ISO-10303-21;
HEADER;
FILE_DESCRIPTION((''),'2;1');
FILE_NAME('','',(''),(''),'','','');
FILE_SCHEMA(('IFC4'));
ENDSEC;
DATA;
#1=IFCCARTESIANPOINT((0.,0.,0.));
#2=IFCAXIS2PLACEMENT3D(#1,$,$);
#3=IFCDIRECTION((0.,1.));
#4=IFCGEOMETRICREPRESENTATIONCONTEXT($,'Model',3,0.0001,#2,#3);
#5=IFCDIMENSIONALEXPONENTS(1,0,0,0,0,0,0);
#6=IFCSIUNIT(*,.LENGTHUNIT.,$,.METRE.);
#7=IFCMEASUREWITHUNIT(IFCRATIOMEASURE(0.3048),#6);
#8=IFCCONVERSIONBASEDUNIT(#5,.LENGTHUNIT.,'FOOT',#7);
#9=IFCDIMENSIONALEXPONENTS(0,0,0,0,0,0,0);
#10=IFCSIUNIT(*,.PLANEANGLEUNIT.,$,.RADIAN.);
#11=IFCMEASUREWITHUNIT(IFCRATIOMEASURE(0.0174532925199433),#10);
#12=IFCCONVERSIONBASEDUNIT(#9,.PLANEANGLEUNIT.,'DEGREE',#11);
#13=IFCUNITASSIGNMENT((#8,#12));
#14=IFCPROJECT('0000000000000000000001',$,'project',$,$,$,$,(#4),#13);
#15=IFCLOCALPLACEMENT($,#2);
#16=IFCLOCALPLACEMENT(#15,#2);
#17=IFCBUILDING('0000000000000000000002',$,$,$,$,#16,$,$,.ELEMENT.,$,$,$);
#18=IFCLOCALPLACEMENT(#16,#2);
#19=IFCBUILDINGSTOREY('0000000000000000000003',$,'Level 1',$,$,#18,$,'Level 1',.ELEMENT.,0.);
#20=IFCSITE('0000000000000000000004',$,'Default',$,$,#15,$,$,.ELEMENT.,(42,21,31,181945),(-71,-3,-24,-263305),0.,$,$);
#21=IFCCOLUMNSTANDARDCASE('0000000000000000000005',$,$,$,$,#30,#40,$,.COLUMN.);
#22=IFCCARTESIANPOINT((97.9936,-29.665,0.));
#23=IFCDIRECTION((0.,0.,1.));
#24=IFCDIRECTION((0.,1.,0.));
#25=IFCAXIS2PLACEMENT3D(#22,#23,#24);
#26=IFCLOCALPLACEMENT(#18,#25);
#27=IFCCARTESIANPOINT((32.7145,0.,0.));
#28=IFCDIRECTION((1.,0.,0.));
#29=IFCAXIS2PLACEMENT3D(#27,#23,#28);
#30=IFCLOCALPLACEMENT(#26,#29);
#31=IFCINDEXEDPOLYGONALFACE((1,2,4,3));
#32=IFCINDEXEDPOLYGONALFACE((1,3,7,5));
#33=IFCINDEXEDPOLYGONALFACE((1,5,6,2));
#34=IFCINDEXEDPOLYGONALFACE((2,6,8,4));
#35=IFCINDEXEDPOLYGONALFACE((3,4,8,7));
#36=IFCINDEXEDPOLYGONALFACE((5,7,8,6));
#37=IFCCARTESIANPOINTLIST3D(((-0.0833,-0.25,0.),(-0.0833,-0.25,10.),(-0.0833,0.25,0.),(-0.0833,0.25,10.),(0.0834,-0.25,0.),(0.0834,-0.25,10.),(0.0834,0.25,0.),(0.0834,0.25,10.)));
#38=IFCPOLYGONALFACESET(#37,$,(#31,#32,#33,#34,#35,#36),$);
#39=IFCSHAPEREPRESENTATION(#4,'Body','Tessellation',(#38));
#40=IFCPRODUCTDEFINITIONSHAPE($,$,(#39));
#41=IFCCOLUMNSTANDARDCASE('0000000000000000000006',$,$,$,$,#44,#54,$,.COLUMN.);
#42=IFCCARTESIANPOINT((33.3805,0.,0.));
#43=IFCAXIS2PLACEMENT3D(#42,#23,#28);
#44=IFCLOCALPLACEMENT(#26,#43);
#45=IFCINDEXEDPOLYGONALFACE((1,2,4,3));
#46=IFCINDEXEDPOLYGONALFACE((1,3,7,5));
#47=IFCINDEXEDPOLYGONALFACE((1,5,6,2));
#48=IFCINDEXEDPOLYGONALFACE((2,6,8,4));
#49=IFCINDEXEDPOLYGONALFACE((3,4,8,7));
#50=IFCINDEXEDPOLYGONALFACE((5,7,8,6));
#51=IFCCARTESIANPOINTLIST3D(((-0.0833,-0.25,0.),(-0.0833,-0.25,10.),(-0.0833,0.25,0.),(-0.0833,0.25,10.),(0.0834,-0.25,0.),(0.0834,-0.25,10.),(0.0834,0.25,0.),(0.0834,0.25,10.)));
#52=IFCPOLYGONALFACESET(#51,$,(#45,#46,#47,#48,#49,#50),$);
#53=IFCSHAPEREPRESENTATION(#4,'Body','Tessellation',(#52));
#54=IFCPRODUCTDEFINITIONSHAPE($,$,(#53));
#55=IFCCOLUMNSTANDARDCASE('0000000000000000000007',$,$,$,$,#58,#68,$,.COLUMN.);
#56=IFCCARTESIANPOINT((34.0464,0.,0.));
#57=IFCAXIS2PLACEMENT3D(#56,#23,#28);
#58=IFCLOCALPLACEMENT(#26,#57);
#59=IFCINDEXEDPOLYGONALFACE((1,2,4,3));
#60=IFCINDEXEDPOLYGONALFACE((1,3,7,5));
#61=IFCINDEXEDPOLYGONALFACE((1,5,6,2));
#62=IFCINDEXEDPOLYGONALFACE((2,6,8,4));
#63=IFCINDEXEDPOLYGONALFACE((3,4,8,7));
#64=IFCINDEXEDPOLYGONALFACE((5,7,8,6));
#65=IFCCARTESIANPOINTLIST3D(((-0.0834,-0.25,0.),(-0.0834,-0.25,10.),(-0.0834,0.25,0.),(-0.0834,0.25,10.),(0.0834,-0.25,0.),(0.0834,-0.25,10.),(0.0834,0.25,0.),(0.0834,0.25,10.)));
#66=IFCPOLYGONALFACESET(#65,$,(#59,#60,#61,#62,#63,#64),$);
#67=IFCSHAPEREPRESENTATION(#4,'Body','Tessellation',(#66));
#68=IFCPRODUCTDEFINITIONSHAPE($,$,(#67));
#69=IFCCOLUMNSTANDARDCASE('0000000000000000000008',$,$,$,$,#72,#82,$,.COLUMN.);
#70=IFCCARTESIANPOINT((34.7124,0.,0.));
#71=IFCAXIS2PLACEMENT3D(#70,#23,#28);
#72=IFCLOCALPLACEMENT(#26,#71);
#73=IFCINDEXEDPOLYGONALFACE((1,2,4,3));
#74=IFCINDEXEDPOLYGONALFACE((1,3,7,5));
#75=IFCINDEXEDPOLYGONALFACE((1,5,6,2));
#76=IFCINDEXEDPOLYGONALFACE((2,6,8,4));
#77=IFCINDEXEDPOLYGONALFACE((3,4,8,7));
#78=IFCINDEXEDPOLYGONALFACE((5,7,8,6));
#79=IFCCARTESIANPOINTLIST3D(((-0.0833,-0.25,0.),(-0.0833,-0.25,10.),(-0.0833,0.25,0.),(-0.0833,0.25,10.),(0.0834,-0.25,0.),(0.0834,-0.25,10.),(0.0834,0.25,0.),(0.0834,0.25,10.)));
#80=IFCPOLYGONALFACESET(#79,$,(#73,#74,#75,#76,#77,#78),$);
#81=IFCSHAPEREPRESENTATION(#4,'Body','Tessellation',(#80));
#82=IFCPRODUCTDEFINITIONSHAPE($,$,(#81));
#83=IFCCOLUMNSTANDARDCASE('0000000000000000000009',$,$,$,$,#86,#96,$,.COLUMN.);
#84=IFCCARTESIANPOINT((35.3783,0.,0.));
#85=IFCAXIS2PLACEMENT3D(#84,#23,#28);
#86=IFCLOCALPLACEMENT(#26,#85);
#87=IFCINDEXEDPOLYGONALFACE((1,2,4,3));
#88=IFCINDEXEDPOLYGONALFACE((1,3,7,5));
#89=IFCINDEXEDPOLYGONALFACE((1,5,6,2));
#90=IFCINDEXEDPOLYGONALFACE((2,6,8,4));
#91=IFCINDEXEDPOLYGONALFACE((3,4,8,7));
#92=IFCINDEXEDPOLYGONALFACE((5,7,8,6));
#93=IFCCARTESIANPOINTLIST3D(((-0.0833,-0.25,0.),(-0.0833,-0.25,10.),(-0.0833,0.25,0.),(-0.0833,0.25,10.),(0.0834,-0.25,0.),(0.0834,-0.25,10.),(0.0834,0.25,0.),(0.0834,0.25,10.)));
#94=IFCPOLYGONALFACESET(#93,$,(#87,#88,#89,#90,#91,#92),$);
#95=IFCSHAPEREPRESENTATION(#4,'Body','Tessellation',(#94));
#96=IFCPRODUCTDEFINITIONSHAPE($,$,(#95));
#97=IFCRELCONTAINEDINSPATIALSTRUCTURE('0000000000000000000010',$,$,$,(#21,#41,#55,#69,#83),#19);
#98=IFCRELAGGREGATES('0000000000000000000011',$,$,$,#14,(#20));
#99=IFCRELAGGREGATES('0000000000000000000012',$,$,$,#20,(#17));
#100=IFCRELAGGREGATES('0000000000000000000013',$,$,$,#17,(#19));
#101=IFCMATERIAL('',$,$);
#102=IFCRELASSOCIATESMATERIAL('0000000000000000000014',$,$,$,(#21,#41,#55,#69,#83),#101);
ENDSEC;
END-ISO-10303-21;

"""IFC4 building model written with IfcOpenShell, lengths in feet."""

from ifc_helpers import new_model, entity, si_unit, converted_unit, direction, frame, origin, place, context, project, spatial, rectangle, extrude, material, element, save


model = new_model("IFC4")

# Units and contexts
model_context = context("Model", 3, precision=0.0001, world=origin(), true_north=direction((0.0, 1.0)))
ifc_project = project(units=[converted_unit("LENGTHUNIT", "FOOT", entity("IfcRatioMeasure", 0.3048), si_unit("LENGTHUNIT", "METRE"), dimensions=[1, 0, 0, 0, 0, 0, 0]), converted_unit("PLANEANGLEUNIT", "DEGREE", entity("IfcRatioMeasure", 0.0174532925199433), si_unit("PLANEANGLEUNIT", "RADIAN"), dimensions=[0, 0, 0, 0, 0, 0, 0])], contexts=[model_context])

# Site, building, storey
site_placement = place(None, origin())
site = spatial("IfcSite", under=ifc_project, at=site_placement, Name="Default", CompositionType="ELEMENT", RefLatitude=(42, 21, 31, 181945), RefLongitude=(-71, -3, -24, -263305), RefElevation=0.0)
building_placement = place(site_placement, origin())
building = spatial("IfcBuilding", under=site, at=building_placement, CompositionType="ELEMENT")
storey_placement = place(building_placement, origin())
storey = spatial("IfcBuildingStorey", under=building, at=storey_placement, Name="Level 1", LongName="Level 1", CompositionType="ELEMENT", Elevation=0.0)

# Columns
ifc_material = material(Name="")
placement = place(storey_placement, frame((97.9936, -29.665, 0.0), z_axis=(0.0, 0.0, 1.0), x_axis=(0.0, 1.0, 0.0)))
for number, where, z_axis, x_axis in (
    (1, (32.7145, 0.0, 0.0), (0.0, 0.0, 1.0), (1.0, 0.0, 0.0)),
    (2, (33.3805, 0.0, 0.0), (0.0, 0.0, 1.0), (1.0, 0.0, 0.0)),
    (3, (34.0464, 0.0, 0.0), (0.0, 0.0, 1.0), (1.0, 0.0, 0.0)),
    (4, (34.7124, 0.0, 0.0), (0.0, 0.0, 1.0), (1.0, 0.0, 0.0)),
    (5, (35.3783, 0.0, 0.0), (0.0, 0.0, 1.0), (1.0, 0.0, 0.0)),
):
    element("IfcColumnStandardCase", number, at=place(placement, frame(where, z_axis=z_axis, x_axis=x_axis)), inside=storey, material=ifc_material, PredefinedType="COLUMN", context=model_context, shape_type="SweptSolid", body=[
        extrude(rectangle(XDim=0.1667, YDim=0.5), origin(), (0.0, 0.0, 1.0), 10.0),
    ])

save(model, "model.ifc")
